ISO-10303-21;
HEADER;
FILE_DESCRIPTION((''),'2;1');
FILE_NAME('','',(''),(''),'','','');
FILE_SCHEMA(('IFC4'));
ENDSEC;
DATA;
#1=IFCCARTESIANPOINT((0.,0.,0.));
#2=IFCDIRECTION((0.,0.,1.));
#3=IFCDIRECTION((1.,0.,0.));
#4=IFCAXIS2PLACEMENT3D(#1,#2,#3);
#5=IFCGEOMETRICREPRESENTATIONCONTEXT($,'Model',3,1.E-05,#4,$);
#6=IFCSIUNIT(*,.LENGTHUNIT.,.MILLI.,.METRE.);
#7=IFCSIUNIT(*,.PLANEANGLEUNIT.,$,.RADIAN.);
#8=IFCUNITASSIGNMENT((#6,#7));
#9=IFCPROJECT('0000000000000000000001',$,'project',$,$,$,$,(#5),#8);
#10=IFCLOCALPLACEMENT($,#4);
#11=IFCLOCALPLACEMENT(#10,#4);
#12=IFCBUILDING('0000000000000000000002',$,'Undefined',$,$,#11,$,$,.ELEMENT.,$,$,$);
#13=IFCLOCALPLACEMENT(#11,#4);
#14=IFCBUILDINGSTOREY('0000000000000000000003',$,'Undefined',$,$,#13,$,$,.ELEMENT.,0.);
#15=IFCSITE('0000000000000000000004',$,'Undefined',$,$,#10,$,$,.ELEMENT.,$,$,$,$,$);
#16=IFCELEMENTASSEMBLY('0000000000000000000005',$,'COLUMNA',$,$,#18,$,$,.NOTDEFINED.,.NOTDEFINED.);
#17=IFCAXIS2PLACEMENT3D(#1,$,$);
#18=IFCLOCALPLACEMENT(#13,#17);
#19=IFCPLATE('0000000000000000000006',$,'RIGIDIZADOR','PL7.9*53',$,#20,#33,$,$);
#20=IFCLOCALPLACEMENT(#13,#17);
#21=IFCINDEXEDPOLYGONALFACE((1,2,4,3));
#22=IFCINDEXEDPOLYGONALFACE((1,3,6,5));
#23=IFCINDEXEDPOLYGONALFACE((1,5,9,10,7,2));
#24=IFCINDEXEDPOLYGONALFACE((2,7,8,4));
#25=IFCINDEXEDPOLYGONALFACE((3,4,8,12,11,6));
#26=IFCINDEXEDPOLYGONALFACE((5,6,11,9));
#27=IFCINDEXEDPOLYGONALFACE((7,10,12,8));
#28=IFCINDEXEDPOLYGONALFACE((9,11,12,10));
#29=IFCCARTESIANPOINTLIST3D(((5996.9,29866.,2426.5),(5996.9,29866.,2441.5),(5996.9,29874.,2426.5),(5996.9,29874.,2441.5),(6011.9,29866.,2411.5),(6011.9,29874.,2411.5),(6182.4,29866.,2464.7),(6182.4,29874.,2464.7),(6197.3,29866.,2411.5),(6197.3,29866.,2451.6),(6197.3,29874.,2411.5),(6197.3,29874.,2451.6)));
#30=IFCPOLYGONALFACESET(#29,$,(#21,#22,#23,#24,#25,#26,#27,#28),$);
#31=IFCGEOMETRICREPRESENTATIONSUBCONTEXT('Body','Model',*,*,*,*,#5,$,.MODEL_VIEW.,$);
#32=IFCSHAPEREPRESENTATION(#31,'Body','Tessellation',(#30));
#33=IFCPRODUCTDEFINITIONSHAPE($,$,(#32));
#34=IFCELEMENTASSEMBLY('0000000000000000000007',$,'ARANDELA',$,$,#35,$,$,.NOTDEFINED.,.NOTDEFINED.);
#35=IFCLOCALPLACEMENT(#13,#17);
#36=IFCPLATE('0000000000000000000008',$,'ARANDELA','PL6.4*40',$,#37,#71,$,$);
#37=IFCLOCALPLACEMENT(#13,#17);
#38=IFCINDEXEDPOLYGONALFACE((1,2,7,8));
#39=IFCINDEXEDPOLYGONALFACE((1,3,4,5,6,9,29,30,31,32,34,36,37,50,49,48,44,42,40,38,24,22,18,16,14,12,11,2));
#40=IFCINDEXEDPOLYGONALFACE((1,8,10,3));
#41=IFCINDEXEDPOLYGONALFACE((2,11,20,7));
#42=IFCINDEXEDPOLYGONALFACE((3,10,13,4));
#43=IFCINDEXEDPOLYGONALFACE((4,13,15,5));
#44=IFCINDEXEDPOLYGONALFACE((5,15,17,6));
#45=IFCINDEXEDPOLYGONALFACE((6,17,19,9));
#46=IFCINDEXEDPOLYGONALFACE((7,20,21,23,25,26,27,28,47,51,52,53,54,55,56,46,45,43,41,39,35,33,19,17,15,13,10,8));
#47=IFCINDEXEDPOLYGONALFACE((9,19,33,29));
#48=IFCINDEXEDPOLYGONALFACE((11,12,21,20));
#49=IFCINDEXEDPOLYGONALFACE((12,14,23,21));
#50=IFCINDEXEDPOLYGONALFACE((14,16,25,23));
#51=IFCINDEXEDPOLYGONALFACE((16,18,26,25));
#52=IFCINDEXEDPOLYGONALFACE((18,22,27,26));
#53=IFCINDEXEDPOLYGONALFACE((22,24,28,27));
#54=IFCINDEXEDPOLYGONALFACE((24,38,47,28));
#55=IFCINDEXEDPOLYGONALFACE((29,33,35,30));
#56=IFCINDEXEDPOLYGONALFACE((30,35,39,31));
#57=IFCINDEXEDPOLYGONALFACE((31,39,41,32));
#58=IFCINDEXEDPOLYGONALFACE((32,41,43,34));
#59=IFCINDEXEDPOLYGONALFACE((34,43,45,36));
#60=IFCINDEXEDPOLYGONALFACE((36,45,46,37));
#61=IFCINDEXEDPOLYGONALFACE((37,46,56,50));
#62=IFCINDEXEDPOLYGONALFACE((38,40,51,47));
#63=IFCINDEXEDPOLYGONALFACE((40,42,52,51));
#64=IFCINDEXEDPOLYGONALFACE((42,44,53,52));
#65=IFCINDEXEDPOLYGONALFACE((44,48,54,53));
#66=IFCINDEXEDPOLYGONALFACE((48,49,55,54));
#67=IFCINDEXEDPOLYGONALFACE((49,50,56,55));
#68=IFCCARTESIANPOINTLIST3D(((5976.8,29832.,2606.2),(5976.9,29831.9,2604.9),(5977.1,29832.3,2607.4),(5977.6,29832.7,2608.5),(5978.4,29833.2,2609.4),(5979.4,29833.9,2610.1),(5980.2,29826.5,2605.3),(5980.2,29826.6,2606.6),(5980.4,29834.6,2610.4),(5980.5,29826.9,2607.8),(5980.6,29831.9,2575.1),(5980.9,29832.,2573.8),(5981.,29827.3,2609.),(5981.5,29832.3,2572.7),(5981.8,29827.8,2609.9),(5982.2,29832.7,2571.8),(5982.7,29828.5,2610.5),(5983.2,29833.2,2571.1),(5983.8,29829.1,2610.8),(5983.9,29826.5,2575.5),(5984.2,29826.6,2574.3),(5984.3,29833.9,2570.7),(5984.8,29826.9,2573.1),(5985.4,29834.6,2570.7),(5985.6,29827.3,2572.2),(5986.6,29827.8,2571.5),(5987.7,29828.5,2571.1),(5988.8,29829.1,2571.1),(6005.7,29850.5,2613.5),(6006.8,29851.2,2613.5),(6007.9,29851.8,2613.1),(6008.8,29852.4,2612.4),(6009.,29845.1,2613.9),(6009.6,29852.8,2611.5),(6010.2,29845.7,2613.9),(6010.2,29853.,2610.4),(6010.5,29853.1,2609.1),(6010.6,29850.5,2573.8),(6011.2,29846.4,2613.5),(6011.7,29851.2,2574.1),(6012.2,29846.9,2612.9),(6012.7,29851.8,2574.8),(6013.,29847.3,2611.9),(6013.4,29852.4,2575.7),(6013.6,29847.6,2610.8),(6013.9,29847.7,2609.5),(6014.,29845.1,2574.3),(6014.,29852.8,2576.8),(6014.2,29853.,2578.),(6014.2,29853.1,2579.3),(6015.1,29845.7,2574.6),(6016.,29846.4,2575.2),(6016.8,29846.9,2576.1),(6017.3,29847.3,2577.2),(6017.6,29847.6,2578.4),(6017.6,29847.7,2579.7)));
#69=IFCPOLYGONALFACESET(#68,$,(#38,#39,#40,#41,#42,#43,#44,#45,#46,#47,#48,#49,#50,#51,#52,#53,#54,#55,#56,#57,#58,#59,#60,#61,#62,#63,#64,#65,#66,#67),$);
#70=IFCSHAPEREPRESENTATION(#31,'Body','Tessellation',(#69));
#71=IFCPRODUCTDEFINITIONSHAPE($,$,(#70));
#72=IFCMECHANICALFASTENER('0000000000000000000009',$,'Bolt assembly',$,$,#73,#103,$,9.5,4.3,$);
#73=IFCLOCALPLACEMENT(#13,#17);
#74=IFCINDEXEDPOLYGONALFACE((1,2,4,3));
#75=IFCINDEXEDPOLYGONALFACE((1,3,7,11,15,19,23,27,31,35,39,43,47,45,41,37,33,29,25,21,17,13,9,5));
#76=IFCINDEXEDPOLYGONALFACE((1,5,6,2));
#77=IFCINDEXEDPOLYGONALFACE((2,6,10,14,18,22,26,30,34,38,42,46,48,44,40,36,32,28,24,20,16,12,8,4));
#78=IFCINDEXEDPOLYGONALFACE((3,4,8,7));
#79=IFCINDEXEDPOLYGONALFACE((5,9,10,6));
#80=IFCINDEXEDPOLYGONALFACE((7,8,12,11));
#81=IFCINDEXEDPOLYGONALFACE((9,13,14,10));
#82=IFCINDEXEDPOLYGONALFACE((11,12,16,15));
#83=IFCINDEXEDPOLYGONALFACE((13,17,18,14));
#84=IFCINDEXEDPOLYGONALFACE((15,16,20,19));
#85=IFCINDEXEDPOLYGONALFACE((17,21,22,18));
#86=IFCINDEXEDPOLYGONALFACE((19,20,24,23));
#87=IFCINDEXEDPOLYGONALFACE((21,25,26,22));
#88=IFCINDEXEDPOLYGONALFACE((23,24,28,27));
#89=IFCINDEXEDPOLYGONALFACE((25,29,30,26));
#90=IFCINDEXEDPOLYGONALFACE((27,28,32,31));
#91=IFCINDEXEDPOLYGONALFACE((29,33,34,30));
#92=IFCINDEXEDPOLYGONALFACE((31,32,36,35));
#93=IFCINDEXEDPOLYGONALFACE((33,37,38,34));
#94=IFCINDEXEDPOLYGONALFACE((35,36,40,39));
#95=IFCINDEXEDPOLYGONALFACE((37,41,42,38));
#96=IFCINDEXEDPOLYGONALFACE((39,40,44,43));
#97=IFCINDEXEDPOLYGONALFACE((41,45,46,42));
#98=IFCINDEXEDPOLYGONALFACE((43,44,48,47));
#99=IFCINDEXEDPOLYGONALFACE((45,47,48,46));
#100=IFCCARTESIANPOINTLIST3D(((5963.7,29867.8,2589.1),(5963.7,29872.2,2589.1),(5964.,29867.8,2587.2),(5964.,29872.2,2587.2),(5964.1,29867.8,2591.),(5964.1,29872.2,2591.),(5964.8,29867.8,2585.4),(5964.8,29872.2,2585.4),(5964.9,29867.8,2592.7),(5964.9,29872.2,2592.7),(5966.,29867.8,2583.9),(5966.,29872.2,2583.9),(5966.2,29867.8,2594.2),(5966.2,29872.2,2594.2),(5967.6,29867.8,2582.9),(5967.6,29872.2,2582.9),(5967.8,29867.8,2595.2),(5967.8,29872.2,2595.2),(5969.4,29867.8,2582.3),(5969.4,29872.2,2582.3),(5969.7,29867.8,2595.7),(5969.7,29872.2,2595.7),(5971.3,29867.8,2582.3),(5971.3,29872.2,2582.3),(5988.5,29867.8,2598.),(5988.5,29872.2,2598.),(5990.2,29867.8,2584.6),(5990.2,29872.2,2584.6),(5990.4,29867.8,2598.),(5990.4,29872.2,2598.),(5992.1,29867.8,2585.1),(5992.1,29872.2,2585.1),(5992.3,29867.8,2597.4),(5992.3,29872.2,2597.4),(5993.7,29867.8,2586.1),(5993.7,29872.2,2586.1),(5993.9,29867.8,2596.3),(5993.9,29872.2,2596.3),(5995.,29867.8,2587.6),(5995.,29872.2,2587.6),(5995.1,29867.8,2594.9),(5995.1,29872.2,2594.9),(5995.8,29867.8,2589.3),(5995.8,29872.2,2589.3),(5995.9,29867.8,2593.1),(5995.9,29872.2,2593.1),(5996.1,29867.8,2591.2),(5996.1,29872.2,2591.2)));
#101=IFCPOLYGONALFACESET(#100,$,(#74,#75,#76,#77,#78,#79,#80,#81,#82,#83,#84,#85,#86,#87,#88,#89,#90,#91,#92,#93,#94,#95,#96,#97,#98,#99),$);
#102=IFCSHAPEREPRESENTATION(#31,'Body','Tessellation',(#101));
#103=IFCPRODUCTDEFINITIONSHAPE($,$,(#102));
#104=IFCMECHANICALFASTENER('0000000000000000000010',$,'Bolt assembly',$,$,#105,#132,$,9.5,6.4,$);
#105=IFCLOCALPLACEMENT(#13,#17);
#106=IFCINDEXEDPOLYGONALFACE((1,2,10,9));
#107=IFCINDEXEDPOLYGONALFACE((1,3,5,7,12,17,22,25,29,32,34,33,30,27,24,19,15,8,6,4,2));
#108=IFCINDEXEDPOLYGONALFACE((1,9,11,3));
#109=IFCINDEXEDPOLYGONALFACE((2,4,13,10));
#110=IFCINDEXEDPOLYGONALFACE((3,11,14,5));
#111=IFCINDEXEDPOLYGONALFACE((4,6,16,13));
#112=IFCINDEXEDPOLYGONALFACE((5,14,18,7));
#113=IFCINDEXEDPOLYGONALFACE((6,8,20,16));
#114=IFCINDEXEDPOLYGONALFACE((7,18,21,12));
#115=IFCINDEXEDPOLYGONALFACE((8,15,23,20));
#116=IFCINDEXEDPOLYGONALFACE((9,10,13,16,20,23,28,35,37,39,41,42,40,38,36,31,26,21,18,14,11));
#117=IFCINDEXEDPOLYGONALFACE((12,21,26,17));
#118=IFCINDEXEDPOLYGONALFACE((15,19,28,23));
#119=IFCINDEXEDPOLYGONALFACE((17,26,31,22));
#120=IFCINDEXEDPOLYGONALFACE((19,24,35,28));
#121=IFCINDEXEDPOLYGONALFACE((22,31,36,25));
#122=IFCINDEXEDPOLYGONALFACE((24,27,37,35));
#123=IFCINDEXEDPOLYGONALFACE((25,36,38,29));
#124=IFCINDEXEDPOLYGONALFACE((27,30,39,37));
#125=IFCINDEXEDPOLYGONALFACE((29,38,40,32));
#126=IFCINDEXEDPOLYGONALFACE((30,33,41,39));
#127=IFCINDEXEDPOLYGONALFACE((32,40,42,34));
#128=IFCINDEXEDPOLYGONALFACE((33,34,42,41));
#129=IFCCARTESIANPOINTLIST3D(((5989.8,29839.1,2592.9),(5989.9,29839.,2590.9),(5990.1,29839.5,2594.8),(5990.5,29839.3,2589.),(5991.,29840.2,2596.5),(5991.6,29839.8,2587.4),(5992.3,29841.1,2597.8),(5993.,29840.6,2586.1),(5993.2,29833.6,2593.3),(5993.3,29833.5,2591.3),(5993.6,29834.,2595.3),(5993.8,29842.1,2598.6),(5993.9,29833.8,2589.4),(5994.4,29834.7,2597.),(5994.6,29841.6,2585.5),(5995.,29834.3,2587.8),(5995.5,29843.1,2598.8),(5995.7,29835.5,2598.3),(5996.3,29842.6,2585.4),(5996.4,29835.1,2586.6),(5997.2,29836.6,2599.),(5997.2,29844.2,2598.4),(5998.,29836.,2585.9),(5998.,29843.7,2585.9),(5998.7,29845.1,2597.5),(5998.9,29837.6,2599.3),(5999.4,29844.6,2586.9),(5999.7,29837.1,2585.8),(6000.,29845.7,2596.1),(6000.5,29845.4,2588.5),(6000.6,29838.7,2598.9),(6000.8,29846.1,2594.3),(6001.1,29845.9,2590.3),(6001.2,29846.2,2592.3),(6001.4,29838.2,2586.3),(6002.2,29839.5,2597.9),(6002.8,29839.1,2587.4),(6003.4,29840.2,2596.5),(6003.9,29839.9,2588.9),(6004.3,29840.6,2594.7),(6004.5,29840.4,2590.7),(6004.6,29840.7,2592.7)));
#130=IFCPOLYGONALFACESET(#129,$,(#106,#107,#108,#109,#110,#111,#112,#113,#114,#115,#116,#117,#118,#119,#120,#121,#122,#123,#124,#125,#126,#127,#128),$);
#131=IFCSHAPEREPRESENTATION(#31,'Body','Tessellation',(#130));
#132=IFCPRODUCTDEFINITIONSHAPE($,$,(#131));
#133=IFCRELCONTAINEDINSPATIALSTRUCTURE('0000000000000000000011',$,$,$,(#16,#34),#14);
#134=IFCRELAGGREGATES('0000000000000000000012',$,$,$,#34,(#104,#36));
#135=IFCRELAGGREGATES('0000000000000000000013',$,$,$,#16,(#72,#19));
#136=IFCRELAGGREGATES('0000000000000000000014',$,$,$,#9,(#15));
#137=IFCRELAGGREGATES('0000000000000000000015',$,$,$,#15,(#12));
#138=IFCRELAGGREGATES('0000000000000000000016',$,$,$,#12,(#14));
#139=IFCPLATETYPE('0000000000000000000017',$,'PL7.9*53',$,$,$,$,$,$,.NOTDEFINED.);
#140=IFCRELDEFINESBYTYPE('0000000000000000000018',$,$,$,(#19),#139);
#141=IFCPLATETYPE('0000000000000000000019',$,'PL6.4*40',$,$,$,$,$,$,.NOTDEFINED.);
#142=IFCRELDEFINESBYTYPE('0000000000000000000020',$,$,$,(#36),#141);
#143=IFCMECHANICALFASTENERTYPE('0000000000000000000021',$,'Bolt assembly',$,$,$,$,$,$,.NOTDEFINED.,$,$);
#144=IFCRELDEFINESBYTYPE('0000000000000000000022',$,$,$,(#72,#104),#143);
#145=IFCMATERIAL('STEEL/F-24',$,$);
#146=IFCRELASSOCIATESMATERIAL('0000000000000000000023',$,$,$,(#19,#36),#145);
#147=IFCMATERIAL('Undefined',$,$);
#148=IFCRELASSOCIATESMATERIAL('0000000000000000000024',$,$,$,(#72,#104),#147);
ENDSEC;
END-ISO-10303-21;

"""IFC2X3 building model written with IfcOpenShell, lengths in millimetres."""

from ifc_helpers import new_model, si_unit, frame, frame_2d, origin_with_axes, origin_2d_with_axis, place, context, subcontext, project, spatial, polyline, circle_curve, parameter, trimmed, segment, composite_curve, circle, outline, extrude, source, transform, mapped, material, type_object, element, aggregate, save


model = new_model("IFC2X3")

# Units and contexts
model_context = context("Model", 3, precision=1e-05, world=origin_with_axes())
body_context = subcontext(model_context, "Body", "Model", "MODEL_VIEW")
ifc_project = project(units=[si_unit("LENGTHUNIT", "METRE", prefix="MILLI"), si_unit("PLANEANGLEUNIT", "RADIAN")], contexts=[model_context])

# Site, building, storey
site_placement = place(None, origin_with_axes())
site = spatial("IfcSite", under=ifc_project, at=site_placement, Name="Undefined", CompositionType="ELEMENT")
building_placement = place(site_placement, origin_with_axes())
building = spatial("IfcBuilding", under=site, at=building_placement, Name="Undefined", CompositionType="ELEMENT")
storey_placement = place(building_placement, origin_with_axes())
storey = spatial("IfcBuildingStorey", under=building, at=storey_placement, Name="Undefined", CompositionType="ELEMENT", Elevation=0.0)

# Shared definitions
ifc_material_1 = material(Name="STEEL/F-24")

# Element assembly, plate
assembly_1_placement = place(storey_placement, origin_with_axes())
assembly_1 = element("IfcElementAssembly", 1, at=assembly_1_placement, inside=storey, Name="COLUMNA", AssemblyPlace="NOTDEFINED", PredefinedType="NOTDEFINED")
plate_type_1 = type_object("IfcPlateType", Name="PL7.9*53", PredefinedType="NOTDEFINED")
plate_1_placement = place(assembly_1_placement, frame((5996.9, 29870.0, 2441.5), z_axis=(0.0, -1.0, 0.0), x_axis=(0.0, 0.000001, -1.0)))
plate_1 = element("IfcPlate", 2, at=plate_1_placement, type_object=plate_type_1, material=ifc_material_1, Name="RIGIDIZADOR", Description="PL7.9*53", context=body_context, shape_type="SweptSolid", body=[
    extrude(outline(polyline([(0.0, 0.0), (15.0, 0.0), (30.0, 15.0), (30.0, 200.4), (-10.1, 200.4), (-23.2, 185.5), (0.0, 0.0)])), frame((0.0, 0.0, -4.0), z_axis=(0.0, 0.0, 1.0), x_axis=(1.0, 0.0, 0.0)), (0.0, 0.0, 1.0), 7.9),
])

# Element assembly, plate
assembly_2_placement = place(storey_placement, origin_with_axes())
assembly_2 = element("IfcElementAssembly", 3, at=assembly_2_placement, inside=storey, Name="ARANDELA", AssemblyPlace="NOTDEFINED", PredefinedType="NOTDEFINED")
plate_type_2 = type_object("IfcPlateType", Name="PL6.4*40", PredefinedType="NOTDEFINED")
plate_2_placement = place(assembly_2_placement, frame((5977.9, 29829.2, 2610.0), z_axis=(-0.526076, 0.84789, -0.065781), x_axis=(0.841338, 0.530172, 0.105202)))
plate_2 = element("IfcPlate", 4, at=plate_2_placement, type_object=plate_type_2, material=ifc_material_1, Name="ARANDELA", Description="PL6.4*40", context=body_context, shape_type="SweptSolid", body=[
    extrude(outline(composite_curve([segment(trimmed(circle_curve(frame_2d((5.0, 5.0), x_axis=(-1.0, 0.0)), 5.0), [parameter(0.0)], [parameter(1.570796)], True, "PARAMETER"), True, "CONTINUOUS"), segment(polyline([(5.0, 0.0), (35.0, 0.0)]), True, "CONTINUOUS"), segment(trimmed(circle_curve(frame_2d((35.0, 5.0), x_axis=(0.0, -1.0)), 5.0), [parameter(0.0)], [parameter(1.570796)], True, "PARAMETER"), True, "CONTINUOUS"), segment(polyline([(40.0, 5.0), (40.0, 35.0)]), True, "CONTINUOUS"), segment(trimmed(circle_curve(frame_2d((35.0, 35.0), x_axis=(1.0, 0.0)), 5.0), [parameter(0.0)], [parameter(1.570796)], True, "PARAMETER"), True, "CONTINUOUS"), segment(polyline([(35.0, 40.0), (5.0, 40.0)]), True, "CONTINUOUS"), segment(trimmed(circle_curve(frame_2d((5.0, 35.0), x_axis=(0.0, 1.0)), 5.0), [parameter(0.0)], [parameter(1.570796)], True, "PARAMETER"), True, "CONTINUOUS"), segment(polyline([(0.0, 35.0), (0.0, 5.0)]), True, "CONTINUOUS")], self_intersect=True)), frame((0.0, 0.0, -3.2), z_axis=(0.0, 0.0, 1.0), x_axis=(1.0, 0.0, 0.0)), (0.0, 0.0, 1.0), 6.4),
])

# Mechanical fasteners
ifc_material_2 = material(Name="Undefined")
mechanical_fastener_type = type_object("IfcMechanicalFastenerType", Name="Bolt assembly")
shared_shape_1 = source(origin_with_axes(), body_context, "Body", "SweptSolid", [
    extrude(outline(composite_curve([segment(polyline([(-9.5, 6.8), (9.5, 6.8)]), True, "CONTINUOUS"), segment(trimmed(circle_curve(frame_2d((9.5, 0.0), x_axis=(0.0, 1.0)), 6.8), [parameter(0.0)], [parameter(3.141593)], False, "PARAMETER"), True, "CONTINUOUS"), segment(polyline([(9.5, -6.8), (-9.5, -6.8)]), True, "CONTINUOUS"), segment(trimmed(circle_curve(frame_2d((-9.5, 0.0), x_axis=(0.0, -1.0)), 6.8), [parameter(0.0)], [parameter(3.141593)], False, "PARAMETER"), True, "DISCONTINUOUS")], self_intersect=False)), frame((0.0, 0.0, 0.0), z_axis=(0.0, 1.0, 0.0), x_axis=(1.0, 0.0, 0.0)), (0.0, 0.0, 1.0), 4.4),
])
mechanical_fastener_1_placement = place(assembly_1_placement, frame((5979.9, 29867.8, 2590.1), z_axis=(0.124075, 0.0, -0.992273), x_axis=(-0.992273, 0.0, -0.124075)))
mechanical_fastener_1 = element("IfcMechanicalFastener", 5, at=mechanical_fastener_1_placement, type_object=mechanical_fastener_type, material=ifc_material_2, Name="Bolt assembly", NominalDiameter=9.5, NominalLength=4.3, context=body_context, shape_type="MappedRepresentation", body=[
    mapped(shared_shape_1, transform((0.0, 0.0, 0.0))),
])
shared_shape_2 = source(origin_with_axes(), body_context, "Body", "SweptSolid", [
    extrude(circle(Radius=6.8, at=origin_2d_with_axis()), frame((0.0, -6.4, 0.0), z_axis=(0.0, 1.0, 0.0), x_axis=(1.0, 0.0, 0.0)), (0.0, 0.0, 1.0), 6.5),
])
mechanical_fastener_2_placement = place(assembly_2_placement, frame((5995.5, 29842.5, 2592.1), z_axis=(0.841338, 0.530172, 0.105202), x_axis=(0.124075, 0.0, -0.992273)))
mechanical_fastener_2 = element("IfcMechanicalFastener", 6, at=mechanical_fastener_2_placement, type_object=mechanical_fastener_type, material=ifc_material_2, Name="Bolt assembly", NominalDiameter=9.5, NominalLength=6.4, context=body_context, shape_type="MappedRepresentation", body=[
    mapped(shared_shape_2, transform((0.0, 0.0, 0.0))),
])
aggregate(assembly_2, [mechanical_fastener_2, plate_2])

aggregate(assembly_1, [mechanical_fastener_1, plate_1])

save(model, "model.ifc")
